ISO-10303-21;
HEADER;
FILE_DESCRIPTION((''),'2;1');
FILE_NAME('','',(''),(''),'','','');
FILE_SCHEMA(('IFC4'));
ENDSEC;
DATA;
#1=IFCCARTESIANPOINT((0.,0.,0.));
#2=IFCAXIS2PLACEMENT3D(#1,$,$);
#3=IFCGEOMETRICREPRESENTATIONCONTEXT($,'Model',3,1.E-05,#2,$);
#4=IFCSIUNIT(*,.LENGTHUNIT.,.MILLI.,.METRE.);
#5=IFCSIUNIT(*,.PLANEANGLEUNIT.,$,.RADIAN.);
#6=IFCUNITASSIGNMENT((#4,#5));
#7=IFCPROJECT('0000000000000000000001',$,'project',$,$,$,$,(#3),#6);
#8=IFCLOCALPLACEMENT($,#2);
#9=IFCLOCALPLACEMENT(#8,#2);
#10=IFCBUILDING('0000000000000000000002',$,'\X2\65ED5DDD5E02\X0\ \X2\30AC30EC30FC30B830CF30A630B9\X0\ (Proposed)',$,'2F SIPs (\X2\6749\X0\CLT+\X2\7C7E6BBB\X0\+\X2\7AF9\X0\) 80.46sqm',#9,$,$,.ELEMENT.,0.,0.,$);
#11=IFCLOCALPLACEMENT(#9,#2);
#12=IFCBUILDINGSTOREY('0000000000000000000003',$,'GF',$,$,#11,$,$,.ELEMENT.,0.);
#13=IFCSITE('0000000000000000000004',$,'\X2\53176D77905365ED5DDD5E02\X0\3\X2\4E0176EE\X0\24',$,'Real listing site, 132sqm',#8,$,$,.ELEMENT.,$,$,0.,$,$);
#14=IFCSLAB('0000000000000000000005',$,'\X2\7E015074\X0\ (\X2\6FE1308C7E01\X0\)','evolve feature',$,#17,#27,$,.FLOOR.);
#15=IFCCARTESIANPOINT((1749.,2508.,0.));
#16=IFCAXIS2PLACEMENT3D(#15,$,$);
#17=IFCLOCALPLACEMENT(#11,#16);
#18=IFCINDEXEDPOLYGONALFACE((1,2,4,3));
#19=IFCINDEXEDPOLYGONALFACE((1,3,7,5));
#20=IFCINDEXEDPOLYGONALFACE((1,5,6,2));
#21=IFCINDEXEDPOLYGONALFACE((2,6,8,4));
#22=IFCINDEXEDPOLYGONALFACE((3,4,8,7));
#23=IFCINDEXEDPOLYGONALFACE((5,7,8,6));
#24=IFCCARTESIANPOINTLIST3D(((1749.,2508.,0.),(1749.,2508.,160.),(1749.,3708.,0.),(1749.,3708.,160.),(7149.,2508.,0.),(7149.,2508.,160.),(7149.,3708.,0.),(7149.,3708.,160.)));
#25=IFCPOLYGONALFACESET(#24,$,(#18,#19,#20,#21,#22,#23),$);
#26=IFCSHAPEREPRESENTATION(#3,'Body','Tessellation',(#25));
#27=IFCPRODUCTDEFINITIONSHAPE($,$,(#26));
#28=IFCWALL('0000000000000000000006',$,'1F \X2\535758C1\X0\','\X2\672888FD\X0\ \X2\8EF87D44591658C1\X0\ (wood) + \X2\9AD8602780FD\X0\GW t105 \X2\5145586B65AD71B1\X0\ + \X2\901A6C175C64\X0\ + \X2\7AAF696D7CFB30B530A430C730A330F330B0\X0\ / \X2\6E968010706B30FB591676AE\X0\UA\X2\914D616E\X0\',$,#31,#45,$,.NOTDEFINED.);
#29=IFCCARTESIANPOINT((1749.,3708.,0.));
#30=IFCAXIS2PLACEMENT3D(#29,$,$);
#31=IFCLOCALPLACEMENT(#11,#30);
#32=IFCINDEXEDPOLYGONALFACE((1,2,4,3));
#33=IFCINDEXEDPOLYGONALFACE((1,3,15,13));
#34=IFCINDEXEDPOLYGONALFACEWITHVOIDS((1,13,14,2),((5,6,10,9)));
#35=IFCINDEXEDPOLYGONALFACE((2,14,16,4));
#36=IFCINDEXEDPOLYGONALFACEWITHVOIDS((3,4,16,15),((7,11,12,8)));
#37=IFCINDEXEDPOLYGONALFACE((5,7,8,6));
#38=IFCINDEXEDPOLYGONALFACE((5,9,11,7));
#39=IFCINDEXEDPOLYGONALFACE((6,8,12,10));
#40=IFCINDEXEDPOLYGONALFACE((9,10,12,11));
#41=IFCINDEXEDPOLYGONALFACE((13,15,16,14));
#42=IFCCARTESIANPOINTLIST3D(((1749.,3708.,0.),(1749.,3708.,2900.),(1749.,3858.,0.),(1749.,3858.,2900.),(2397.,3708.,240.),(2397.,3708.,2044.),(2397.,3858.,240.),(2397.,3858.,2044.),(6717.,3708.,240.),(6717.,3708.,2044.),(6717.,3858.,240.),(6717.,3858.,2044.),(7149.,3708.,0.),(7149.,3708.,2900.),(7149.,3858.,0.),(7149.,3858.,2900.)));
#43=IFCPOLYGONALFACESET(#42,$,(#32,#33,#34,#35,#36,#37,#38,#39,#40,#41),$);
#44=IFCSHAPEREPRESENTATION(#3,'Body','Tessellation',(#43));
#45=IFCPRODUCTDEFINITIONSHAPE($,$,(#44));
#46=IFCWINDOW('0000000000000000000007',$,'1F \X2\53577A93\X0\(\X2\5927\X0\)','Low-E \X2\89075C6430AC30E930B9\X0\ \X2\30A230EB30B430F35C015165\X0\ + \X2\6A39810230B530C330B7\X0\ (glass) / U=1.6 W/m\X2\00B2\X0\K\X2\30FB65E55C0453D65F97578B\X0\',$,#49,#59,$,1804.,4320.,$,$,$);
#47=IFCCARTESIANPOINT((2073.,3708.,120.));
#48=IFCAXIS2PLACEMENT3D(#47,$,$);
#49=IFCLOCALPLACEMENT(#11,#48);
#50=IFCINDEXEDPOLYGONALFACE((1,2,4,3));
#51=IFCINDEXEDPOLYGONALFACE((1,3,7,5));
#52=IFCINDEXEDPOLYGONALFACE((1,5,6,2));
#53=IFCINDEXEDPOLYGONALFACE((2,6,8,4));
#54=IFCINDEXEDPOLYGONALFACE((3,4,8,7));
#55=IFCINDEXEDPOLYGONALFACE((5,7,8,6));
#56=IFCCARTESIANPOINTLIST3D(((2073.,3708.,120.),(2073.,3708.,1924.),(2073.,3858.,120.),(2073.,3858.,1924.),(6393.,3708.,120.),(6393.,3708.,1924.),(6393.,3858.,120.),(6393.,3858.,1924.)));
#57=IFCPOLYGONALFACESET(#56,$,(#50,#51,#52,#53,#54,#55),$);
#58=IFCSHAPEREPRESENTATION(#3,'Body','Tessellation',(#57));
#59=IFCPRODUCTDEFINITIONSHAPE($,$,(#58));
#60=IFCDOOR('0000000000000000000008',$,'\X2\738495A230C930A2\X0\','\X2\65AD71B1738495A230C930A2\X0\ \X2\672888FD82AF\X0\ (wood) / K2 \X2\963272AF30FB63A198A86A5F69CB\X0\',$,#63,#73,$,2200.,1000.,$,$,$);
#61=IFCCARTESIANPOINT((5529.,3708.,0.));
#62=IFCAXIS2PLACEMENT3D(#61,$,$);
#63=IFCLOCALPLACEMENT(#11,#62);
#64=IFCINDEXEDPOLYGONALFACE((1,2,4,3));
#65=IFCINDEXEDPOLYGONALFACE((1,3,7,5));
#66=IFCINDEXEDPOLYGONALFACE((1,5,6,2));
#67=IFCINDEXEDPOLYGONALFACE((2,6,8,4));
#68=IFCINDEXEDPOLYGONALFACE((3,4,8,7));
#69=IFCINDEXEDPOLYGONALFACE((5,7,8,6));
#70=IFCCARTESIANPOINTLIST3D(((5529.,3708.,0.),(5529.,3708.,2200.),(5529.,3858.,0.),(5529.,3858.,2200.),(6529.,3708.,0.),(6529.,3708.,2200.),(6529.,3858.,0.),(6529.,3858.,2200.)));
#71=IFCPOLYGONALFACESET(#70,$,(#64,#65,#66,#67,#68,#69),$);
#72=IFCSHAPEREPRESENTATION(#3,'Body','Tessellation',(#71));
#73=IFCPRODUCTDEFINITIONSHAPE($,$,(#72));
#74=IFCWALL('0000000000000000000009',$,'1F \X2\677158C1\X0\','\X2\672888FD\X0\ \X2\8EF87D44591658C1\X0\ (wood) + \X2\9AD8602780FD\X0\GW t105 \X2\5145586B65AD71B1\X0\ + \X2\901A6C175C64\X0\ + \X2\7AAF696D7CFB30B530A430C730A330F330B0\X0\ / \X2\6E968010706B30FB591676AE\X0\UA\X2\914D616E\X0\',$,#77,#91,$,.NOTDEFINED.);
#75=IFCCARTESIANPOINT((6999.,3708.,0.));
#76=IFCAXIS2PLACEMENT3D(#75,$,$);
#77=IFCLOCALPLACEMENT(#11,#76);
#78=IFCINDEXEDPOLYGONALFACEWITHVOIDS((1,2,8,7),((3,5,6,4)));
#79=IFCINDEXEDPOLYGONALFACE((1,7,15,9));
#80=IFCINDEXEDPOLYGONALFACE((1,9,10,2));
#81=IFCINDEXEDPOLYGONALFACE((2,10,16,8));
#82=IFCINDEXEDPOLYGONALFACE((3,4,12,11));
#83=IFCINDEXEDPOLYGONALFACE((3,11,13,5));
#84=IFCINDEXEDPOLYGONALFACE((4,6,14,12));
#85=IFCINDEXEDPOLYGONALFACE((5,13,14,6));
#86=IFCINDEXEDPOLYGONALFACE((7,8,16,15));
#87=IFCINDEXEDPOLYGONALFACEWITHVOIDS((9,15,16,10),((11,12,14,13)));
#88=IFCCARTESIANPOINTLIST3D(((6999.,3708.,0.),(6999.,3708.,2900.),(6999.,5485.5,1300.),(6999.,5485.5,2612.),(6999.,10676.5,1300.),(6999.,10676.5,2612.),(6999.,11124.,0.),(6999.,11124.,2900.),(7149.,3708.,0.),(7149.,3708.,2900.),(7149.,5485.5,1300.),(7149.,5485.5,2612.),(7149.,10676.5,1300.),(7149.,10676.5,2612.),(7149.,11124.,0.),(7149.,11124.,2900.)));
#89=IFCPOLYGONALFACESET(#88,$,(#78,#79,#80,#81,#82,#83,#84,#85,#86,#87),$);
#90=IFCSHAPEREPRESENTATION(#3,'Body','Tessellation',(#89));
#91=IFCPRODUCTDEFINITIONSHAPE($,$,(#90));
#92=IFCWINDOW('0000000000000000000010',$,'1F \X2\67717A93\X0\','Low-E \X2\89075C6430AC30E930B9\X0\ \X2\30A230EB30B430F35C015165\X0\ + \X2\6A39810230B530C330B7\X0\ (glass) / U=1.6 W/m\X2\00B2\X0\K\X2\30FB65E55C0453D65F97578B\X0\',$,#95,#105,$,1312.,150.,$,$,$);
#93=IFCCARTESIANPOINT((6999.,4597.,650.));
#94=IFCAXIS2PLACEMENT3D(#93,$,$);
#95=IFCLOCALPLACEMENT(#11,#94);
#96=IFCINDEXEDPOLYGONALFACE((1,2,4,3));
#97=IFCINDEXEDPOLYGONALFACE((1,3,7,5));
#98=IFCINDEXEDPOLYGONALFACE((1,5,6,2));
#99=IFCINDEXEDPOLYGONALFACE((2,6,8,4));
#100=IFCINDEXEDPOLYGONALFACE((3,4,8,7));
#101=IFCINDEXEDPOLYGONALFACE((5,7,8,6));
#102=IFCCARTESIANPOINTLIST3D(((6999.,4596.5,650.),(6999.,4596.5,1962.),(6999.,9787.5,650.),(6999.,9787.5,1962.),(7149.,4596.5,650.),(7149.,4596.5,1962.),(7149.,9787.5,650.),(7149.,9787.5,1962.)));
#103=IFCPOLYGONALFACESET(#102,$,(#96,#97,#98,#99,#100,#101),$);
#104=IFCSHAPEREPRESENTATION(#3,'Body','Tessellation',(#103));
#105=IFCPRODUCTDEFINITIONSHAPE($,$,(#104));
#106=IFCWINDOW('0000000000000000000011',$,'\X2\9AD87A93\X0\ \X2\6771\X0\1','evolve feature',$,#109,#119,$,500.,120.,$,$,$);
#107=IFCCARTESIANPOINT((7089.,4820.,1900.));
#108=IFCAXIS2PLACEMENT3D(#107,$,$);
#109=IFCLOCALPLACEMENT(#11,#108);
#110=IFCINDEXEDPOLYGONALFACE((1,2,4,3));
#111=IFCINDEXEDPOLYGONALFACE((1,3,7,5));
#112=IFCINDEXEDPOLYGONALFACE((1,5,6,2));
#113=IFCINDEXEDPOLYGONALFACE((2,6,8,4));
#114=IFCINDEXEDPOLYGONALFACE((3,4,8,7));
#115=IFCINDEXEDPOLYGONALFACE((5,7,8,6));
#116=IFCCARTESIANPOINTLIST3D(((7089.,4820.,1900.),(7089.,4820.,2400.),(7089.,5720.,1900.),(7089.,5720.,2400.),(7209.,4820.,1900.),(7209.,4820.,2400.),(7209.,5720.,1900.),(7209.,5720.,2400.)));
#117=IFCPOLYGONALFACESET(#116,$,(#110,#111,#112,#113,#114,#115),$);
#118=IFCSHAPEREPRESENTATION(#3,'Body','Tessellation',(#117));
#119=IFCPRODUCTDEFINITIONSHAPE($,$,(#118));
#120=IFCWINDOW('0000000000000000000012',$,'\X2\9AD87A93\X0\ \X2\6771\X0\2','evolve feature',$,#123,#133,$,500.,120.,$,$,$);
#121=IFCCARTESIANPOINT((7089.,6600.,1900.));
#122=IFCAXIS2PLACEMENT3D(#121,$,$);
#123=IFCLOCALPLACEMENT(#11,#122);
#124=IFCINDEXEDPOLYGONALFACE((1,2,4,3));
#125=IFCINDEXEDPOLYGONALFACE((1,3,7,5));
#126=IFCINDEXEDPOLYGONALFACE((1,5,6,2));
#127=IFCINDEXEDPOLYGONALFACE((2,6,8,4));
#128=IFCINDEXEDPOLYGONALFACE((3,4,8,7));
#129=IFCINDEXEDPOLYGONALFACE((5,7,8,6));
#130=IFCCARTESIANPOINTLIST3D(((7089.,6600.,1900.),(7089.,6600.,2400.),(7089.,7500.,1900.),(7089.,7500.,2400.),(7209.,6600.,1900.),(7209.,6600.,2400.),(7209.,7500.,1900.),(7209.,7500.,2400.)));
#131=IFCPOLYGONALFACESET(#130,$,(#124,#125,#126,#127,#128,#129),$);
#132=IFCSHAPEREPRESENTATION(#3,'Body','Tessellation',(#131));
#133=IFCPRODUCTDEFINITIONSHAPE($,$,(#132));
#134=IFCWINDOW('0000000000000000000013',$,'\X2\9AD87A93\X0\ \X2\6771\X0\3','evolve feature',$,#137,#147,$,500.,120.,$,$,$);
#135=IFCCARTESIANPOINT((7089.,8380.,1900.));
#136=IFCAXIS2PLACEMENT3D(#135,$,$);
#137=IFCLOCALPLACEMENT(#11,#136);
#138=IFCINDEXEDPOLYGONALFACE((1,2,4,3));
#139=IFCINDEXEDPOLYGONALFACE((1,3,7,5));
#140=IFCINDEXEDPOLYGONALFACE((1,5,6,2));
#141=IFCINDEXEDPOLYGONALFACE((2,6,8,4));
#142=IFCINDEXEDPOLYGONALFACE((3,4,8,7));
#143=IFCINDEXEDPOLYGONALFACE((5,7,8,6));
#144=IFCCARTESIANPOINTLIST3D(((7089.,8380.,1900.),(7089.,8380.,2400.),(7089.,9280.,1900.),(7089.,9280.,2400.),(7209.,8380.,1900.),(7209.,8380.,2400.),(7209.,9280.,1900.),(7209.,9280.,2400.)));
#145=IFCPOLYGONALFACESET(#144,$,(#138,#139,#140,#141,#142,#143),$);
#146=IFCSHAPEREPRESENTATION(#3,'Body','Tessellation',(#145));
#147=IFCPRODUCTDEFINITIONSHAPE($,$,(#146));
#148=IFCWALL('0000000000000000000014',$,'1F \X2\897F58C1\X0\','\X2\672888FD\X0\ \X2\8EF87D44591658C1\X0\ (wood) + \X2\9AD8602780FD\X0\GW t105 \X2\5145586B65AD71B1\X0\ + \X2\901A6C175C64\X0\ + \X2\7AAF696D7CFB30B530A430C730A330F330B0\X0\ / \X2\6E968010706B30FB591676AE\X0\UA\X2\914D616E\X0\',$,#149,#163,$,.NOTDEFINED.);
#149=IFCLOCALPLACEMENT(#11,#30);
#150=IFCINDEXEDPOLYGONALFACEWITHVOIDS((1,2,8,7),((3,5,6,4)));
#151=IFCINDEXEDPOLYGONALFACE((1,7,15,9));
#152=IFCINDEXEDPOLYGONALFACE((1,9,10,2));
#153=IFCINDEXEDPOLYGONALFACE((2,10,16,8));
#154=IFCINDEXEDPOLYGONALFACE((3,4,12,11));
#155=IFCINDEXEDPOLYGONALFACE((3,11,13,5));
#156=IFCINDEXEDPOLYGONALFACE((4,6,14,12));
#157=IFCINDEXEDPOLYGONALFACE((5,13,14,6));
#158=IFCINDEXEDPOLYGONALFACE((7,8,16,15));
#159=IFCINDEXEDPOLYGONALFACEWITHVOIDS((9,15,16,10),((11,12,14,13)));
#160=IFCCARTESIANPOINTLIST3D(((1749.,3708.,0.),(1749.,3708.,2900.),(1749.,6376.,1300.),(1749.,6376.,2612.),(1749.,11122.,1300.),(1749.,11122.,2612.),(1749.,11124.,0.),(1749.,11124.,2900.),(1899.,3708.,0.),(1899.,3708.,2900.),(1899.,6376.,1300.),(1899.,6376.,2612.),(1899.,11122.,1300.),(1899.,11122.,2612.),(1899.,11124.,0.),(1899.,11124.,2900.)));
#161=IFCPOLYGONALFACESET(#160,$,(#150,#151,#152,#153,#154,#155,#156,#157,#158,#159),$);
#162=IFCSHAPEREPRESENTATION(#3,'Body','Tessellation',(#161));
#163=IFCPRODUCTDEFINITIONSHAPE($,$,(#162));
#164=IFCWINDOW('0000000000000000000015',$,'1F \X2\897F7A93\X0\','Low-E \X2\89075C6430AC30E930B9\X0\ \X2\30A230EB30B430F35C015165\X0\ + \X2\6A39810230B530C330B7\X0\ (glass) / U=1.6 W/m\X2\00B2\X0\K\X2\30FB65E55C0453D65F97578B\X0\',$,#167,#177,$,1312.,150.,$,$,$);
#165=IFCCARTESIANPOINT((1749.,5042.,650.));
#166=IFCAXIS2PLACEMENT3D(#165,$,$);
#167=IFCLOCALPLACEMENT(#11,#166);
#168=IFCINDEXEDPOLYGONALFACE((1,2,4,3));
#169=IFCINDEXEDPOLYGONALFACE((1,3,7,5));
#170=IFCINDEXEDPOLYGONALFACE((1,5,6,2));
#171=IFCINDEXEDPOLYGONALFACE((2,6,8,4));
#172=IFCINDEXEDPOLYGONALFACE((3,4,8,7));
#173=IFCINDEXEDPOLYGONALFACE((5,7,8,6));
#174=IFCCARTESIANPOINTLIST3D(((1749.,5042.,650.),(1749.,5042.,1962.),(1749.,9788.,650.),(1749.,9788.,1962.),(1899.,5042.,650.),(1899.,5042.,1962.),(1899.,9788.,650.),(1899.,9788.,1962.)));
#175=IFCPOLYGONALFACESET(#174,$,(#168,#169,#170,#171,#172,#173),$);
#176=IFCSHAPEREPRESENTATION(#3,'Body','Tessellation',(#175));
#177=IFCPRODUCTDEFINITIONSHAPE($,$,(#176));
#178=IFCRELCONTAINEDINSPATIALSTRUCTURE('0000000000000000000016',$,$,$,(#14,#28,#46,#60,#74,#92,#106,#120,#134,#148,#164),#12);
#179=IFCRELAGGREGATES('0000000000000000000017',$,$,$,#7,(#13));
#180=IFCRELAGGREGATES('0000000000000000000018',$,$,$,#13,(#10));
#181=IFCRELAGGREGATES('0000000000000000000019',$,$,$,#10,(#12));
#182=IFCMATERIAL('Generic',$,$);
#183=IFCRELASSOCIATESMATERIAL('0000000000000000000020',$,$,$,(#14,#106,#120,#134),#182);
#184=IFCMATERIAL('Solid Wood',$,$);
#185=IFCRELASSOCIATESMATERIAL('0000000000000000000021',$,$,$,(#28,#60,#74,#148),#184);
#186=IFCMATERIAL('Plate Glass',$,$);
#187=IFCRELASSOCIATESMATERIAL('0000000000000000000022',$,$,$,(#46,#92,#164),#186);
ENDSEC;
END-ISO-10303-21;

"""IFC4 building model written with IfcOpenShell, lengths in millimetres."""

from ifc_helpers import new_model, si_unit, frame, frame_2d, origin, place, context, project, spatial, rectangle, extrude, material, element, fill, save


model = new_model("IFC4")

# Units and contexts
model_context = context("Model", 3, precision=1e-05, world=origin())
ifc_project = project(units=[si_unit("LENGTHUNIT", "METRE", prefix="MILLI"), si_unit("PLANEANGLEUNIT", "RADIAN")], contexts=[model_context])

# Site, building, storey
site_placement = place(None, origin())
site = spatial("IfcSite", under=ifc_project, at=site_placement, Name="北海道旭川市3丁目24", ObjectType="Real listing site, 132sqm", CompositionType="ELEMENT", RefElevation=0.0)
building_placement = place(site_placement, origin())
building = spatial("IfcBuilding", under=site, at=building_placement, Name="旭川市 ガレージハウス (Proposed)", ObjectType="2F SIPs (杉CLT+籾殻+竹) 80.46sqm", CompositionType="ELEMENT", ElevationOfRefHeight=0.0, ElevationOfTerrain=0.0)
storey_placement = place(building_placement, origin())
storey = spatial("IfcBuildingStorey", under=building, at=storey_placement, Name="GF", CompositionType="ELEMENT", Elevation=0.0)

# Slab
ifc_material_1 = material(Name="Solid Wood")
ifc_material_2 = material(Name="Generic")
slab_1_placement = place(storey_placement, frame((1749.0, 2508.0, 0.0)))
element("IfcSlab", 1, at=slab_1_placement, inside=storey, material=ifc_material_2, Name="縁側 (濡れ縁)", Description="evolve feature", PredefinedType="FLOOR", context=model_context, shape_type="SweptSolid", body=[
    extrude(rectangle(XDim=5400.0, YDim=1200.0, at=frame_2d((2700.0, 600.0))), frame((1749.0, 2508.0, 0.0)), (0.0, 0.0, 1.0), 160.0),
])

# Wall, openings, window, door
wall_1_placement = place(storey_placement, frame((1749.0, 3708.0, 0.0)))
wall_1 = element("IfcWall", 2, at=wall_1_placement, inside=storey, material=ifc_material_1, Name="1F 南壁", Description="木製 軸組外壁 (wood) + 高性能GW t105 充填断熱 + 通気層 + 窯業系サイディング / 準耐火・外皮UA配慮", PredefinedType="NOTDEFINED", context=model_context, shape_type="SweptSolid", body=[
    extrude(rectangle(XDim=5400.0, YDim=150.0, at=frame_2d((2700.0, 75.0))), frame((1749.0, 3708.0, 0.0)), (0.0, 0.0, 1.0), 2900.0),
])
opening_1_placement = place(storey_placement, frame((2073.0, 3708.0, 120.0)))
opening_1 = element("IfcOpeningElement", 3, at=opening_1_placement, cuts=wall_1, PredefinedType="NOTDEFINED", context=model_context, shape_type="SweptSolid", body=[
    extrude(rectangle(XDim=4320.0, YDim=150.0, at=frame_2d((2160.0, 75.0))), frame((2073.0, 3708.0, 120.0)), (0.0, 0.0, 1.0), 1804.0),
])
opening_2_placement = place(storey_placement, frame((5529.0, 3708.0, 0.0)))
opening_2 = element("IfcOpeningElement", 4, at=opening_2_placement, cuts=wall_1, PredefinedType="NOTDEFINED", context=model_context, shape_type="SweptSolid", body=[
    extrude(rectangle(XDim=1000.0, YDim=150.0, at=frame_2d((500.0, 75.0))), frame((5529.0, 3708.0, 0.0)), (0.0, 0.0, 1.0), 2200.0),
])
ifc_material_3 = material(Name="Plate Glass")
window_1_placement = place(storey_placement, frame((2073.0, 3708.0, 120.0)))
window_1 = element("IfcWindow", 5, at=window_1_placement, inside=storey, material=ifc_material_3, Name="1F 南窓(大)", Description="Low-E 複層ガラス アルゴン封入 + 樹脂サッシ (glass) / U=1.6 W/m²K・日射取得型", OverallHeight=1804.0, OverallWidth=4320.0, context=model_context, shape_type="SweptSolid", body=[
    extrude(rectangle(XDim=4320.0, YDim=150.0, at=frame_2d((2160.0, 75.0))), frame((2073.0, 3708.0, 120.0)), (0.0, 0.0, 1.0), 1804.0),
])
fill(opening_1, window_1)
door_placement = place(storey_placement, frame((5529.0, 3708.0, 0.0)))
door = element("IfcDoor", 6, at=door_placement, inside=storey, material=ifc_material_1, Name="玄関ドア", Description="断熱玄関ドア 木製芯 (wood) / K2 防犯・採風機構", OverallHeight=2200.0, OverallWidth=1000.0, context=model_context, shape_type="SweptSolid", body=[
    extrude(rectangle(XDim=1000.0, YDim=150.0, at=frame_2d((500.0, 75.0))), frame((5529.0, 3708.0, 0.0)), (0.0, 0.0, 1.0), 2200.0),
])
fill(opening_2, door)

# Wall, openings, windows
wall_2_placement = place(storey_placement, frame((6999.0, 3708.0, 0.0)))
wall_2 = element("IfcWall", 7, at=wall_2_placement, inside=storey, material=ifc_material_1, Name="1F 東壁", Description="木製 軸組外壁 (wood) + 高性能GW t105 充填断熱 + 通気層 + 窯業系サイディング / 準耐火・外皮UA配慮", PredefinedType="NOTDEFINED", context=model_context, shape_type="SweptSolid", body=[
    extrude(rectangle(XDim=150.0, YDim=7416.0, at=frame_2d((75.0, 3708.0))), frame((6999.0, 3708.0, 0.0)), (0.0, 0.0, 1.0), 2900.0),
])
opening_3_placement = place(storey_placement, frame((6999.0, 4597.0, 650.0)))
opening_3 = element("IfcOpeningElement", 8, at=opening_3_placement, cuts=wall_2, PredefinedType="NOTDEFINED", context=model_context, shape_type="SweptSolid", body=[
    extrude(rectangle(XDim=150.0, YDim=5191.0, at=frame_2d((75.0, 2595.0))), frame((6999.0, 4597.0, 650.0)), (0.0, 0.0, 1.0), 1312.0),
])
opening_4_placement = place(storey_placement, frame((7089.0, 4820.0, 1900.0)))
opening_4 = element("IfcOpeningElement", 9, at=opening_4_placement, cuts=wall_2, PredefinedType="NOTDEFINED", context=model_context, shape_type="SweptSolid", body=[
    extrude(rectangle(XDim=120.0, YDim=900.0, at=frame_2d((60.0, 450.0))), frame((7089.0, 4820.0, 1900.0)), (0.0, 0.0, 1.0), 500.0),
])
opening_5_placement = place(storey_placement, frame((7089.0, 6600.0, 1900.0)))
opening_5 = element("IfcOpeningElement", 10, at=opening_5_placement, cuts=wall_2, PredefinedType="NOTDEFINED", context=model_context, shape_type="SweptSolid", body=[
    extrude(rectangle(XDim=120.0, YDim=900.0, at=frame_2d((60.0, 450.0))), frame((7089.0, 6600.0, 1900.0)), (0.0, 0.0, 1.0), 500.0),
])
opening_6_placement = place(storey_placement, frame((7089.0, 8380.0, 1900.0)))
opening_6 = element("IfcOpeningElement", 11, at=opening_6_placement, cuts=wall_2, PredefinedType="NOTDEFINED", context=model_context, shape_type="SweptSolid", body=[
    extrude(rectangle(XDim=120.0, YDim=900.0, at=frame_2d((60.0, 450.0))), frame((7089.0, 8380.0, 1900.0)), (0.0, 0.0, 1.0), 500.0),
])
window_2_placement = place(storey_placement, frame((6999.0, 4597.0, 650.0)))
window_2 = element("IfcWindow", 12, at=window_2_placement, inside=storey, material=ifc_material_3, Name="1F 東窓", Description="Low-E 複層ガラス アルゴン封入 + 樹脂サッシ (glass) / U=1.6 W/m²K・日射取得型", OverallHeight=1312.0, OverallWidth=150.0, context=model_context, shape_type="SweptSolid", body=[
    extrude(rectangle(XDim=150.0, YDim=5191.0, at=frame_2d((75.0, 2595.0))), frame((6999.0, 4597.0, 650.0)), (0.0, 0.0, 1.0), 1312.0),
])
fill(opening_3, window_2)
window_3_placement = place(storey_placement, frame((7089.0, 4820.0, 1900.0)))
window_3 = element("IfcWindow", 13, at=window_3_placement, inside=storey, material=ifc_material_2, Name="高窓 東1", Description="evolve feature", OverallHeight=500.0, OverallWidth=120.0, context=model_context, shape_type="SweptSolid", body=[
    extrude(rectangle(XDim=120.0, YDim=900.0, at=frame_2d((60.0, 450.0))), frame((7089.0, 4820.0, 1900.0)), (0.0, 0.0, 1.0), 500.0),
])
fill(opening_4, window_3)
window_4_placement = place(storey_placement, frame((7089.0, 6600.0, 1900.0)))
window_4 = element("IfcWindow", 14, at=window_4_placement, inside=storey, material=ifc_material_2, Name="高窓 東2", Description="evolve feature", OverallHeight=500.0, OverallWidth=120.0, context=model_context, shape_type="SweptSolid", body=[
    extrude(rectangle(XDim=120.0, YDim=900.0, at=frame_2d((60.0, 450.0))), frame((7089.0, 6600.0, 1900.0)), (0.0, 0.0, 1.0), 500.0),
])
fill(opening_5, window_4)
window_5_placement = place(storey_placement, frame((7089.0, 8380.0, 1900.0)))
window_5 = element("IfcWindow", 15, at=window_5_placement, inside=storey, material=ifc_material_2, Name="高窓 東3", Description="evolve feature", OverallHeight=500.0, OverallWidth=120.0, context=model_context, shape_type="SweptSolid", body=[
    extrude(rectangle(XDim=120.0, YDim=900.0, at=frame_2d((60.0, 450.0))), frame((7089.0, 8380.0, 1900.0)), (0.0, 0.0, 1.0), 500.0),
])
fill(opening_6, window_5)

# Wall, opening, window
wall_3_placement = place(storey_placement, frame((1749.0, 3708.0, 0.0)))
wall_3 = element("IfcWall", 16, at=wall_3_placement, inside=storey, material=ifc_material_1, Name="1F 西壁", Description="木製 軸組外壁 (wood) + 高性能GW t105 充填断熱 + 通気層 + 窯業系サイディング / 準耐火・外皮UA配慮", PredefinedType="NOTDEFINED", context=model_context, shape_type="SweptSolid", body=[
    extrude(rectangle(XDim=150.0, YDim=7416.0, at=frame_2d((75.0, 3708.0))), frame((1749.0, 3708.0, 0.0)), (0.0, 0.0, 1.0), 2900.0),
])
opening_7_placement = place(storey_placement, frame((1749.0, 5042.0, 650.0)))
opening_7 = element("IfcOpeningElement", 17, at=opening_7_placement, cuts=wall_3, PredefinedType="NOTDEFINED", context=model_context, shape_type="SweptSolid", body=[
    extrude(rectangle(XDim=150.0, YDim=4746.0, at=frame_2d((75.0, 2373.0))), frame((1749.0, 5042.0, 650.0)), (0.0, 0.0, 1.0), 1312.0),
])
window_6_placement = place(storey_placement, frame((1749.0, 5042.0, 650.0)))
window_6 = element("IfcWindow", 18, at=window_6_placement, inside=storey, material=ifc_material_3, Name="1F 西窓", Description="Low-E 複層ガラス アルゴン封入 + 樹脂サッシ (glass) / U=1.6 W/m²K・日射取得型", OverallHeight=1312.0, OverallWidth=150.0, context=model_context, shape_type="SweptSolid", body=[
    extrude(rectangle(XDim=150.0, YDim=4746.0, at=frame_2d((75.0, 2373.0))), frame((1749.0, 5042.0, 650.0)), (0.0, 0.0, 1.0), 1312.0),
])
fill(opening_7, window_6)

save(model, "model.ifc")
